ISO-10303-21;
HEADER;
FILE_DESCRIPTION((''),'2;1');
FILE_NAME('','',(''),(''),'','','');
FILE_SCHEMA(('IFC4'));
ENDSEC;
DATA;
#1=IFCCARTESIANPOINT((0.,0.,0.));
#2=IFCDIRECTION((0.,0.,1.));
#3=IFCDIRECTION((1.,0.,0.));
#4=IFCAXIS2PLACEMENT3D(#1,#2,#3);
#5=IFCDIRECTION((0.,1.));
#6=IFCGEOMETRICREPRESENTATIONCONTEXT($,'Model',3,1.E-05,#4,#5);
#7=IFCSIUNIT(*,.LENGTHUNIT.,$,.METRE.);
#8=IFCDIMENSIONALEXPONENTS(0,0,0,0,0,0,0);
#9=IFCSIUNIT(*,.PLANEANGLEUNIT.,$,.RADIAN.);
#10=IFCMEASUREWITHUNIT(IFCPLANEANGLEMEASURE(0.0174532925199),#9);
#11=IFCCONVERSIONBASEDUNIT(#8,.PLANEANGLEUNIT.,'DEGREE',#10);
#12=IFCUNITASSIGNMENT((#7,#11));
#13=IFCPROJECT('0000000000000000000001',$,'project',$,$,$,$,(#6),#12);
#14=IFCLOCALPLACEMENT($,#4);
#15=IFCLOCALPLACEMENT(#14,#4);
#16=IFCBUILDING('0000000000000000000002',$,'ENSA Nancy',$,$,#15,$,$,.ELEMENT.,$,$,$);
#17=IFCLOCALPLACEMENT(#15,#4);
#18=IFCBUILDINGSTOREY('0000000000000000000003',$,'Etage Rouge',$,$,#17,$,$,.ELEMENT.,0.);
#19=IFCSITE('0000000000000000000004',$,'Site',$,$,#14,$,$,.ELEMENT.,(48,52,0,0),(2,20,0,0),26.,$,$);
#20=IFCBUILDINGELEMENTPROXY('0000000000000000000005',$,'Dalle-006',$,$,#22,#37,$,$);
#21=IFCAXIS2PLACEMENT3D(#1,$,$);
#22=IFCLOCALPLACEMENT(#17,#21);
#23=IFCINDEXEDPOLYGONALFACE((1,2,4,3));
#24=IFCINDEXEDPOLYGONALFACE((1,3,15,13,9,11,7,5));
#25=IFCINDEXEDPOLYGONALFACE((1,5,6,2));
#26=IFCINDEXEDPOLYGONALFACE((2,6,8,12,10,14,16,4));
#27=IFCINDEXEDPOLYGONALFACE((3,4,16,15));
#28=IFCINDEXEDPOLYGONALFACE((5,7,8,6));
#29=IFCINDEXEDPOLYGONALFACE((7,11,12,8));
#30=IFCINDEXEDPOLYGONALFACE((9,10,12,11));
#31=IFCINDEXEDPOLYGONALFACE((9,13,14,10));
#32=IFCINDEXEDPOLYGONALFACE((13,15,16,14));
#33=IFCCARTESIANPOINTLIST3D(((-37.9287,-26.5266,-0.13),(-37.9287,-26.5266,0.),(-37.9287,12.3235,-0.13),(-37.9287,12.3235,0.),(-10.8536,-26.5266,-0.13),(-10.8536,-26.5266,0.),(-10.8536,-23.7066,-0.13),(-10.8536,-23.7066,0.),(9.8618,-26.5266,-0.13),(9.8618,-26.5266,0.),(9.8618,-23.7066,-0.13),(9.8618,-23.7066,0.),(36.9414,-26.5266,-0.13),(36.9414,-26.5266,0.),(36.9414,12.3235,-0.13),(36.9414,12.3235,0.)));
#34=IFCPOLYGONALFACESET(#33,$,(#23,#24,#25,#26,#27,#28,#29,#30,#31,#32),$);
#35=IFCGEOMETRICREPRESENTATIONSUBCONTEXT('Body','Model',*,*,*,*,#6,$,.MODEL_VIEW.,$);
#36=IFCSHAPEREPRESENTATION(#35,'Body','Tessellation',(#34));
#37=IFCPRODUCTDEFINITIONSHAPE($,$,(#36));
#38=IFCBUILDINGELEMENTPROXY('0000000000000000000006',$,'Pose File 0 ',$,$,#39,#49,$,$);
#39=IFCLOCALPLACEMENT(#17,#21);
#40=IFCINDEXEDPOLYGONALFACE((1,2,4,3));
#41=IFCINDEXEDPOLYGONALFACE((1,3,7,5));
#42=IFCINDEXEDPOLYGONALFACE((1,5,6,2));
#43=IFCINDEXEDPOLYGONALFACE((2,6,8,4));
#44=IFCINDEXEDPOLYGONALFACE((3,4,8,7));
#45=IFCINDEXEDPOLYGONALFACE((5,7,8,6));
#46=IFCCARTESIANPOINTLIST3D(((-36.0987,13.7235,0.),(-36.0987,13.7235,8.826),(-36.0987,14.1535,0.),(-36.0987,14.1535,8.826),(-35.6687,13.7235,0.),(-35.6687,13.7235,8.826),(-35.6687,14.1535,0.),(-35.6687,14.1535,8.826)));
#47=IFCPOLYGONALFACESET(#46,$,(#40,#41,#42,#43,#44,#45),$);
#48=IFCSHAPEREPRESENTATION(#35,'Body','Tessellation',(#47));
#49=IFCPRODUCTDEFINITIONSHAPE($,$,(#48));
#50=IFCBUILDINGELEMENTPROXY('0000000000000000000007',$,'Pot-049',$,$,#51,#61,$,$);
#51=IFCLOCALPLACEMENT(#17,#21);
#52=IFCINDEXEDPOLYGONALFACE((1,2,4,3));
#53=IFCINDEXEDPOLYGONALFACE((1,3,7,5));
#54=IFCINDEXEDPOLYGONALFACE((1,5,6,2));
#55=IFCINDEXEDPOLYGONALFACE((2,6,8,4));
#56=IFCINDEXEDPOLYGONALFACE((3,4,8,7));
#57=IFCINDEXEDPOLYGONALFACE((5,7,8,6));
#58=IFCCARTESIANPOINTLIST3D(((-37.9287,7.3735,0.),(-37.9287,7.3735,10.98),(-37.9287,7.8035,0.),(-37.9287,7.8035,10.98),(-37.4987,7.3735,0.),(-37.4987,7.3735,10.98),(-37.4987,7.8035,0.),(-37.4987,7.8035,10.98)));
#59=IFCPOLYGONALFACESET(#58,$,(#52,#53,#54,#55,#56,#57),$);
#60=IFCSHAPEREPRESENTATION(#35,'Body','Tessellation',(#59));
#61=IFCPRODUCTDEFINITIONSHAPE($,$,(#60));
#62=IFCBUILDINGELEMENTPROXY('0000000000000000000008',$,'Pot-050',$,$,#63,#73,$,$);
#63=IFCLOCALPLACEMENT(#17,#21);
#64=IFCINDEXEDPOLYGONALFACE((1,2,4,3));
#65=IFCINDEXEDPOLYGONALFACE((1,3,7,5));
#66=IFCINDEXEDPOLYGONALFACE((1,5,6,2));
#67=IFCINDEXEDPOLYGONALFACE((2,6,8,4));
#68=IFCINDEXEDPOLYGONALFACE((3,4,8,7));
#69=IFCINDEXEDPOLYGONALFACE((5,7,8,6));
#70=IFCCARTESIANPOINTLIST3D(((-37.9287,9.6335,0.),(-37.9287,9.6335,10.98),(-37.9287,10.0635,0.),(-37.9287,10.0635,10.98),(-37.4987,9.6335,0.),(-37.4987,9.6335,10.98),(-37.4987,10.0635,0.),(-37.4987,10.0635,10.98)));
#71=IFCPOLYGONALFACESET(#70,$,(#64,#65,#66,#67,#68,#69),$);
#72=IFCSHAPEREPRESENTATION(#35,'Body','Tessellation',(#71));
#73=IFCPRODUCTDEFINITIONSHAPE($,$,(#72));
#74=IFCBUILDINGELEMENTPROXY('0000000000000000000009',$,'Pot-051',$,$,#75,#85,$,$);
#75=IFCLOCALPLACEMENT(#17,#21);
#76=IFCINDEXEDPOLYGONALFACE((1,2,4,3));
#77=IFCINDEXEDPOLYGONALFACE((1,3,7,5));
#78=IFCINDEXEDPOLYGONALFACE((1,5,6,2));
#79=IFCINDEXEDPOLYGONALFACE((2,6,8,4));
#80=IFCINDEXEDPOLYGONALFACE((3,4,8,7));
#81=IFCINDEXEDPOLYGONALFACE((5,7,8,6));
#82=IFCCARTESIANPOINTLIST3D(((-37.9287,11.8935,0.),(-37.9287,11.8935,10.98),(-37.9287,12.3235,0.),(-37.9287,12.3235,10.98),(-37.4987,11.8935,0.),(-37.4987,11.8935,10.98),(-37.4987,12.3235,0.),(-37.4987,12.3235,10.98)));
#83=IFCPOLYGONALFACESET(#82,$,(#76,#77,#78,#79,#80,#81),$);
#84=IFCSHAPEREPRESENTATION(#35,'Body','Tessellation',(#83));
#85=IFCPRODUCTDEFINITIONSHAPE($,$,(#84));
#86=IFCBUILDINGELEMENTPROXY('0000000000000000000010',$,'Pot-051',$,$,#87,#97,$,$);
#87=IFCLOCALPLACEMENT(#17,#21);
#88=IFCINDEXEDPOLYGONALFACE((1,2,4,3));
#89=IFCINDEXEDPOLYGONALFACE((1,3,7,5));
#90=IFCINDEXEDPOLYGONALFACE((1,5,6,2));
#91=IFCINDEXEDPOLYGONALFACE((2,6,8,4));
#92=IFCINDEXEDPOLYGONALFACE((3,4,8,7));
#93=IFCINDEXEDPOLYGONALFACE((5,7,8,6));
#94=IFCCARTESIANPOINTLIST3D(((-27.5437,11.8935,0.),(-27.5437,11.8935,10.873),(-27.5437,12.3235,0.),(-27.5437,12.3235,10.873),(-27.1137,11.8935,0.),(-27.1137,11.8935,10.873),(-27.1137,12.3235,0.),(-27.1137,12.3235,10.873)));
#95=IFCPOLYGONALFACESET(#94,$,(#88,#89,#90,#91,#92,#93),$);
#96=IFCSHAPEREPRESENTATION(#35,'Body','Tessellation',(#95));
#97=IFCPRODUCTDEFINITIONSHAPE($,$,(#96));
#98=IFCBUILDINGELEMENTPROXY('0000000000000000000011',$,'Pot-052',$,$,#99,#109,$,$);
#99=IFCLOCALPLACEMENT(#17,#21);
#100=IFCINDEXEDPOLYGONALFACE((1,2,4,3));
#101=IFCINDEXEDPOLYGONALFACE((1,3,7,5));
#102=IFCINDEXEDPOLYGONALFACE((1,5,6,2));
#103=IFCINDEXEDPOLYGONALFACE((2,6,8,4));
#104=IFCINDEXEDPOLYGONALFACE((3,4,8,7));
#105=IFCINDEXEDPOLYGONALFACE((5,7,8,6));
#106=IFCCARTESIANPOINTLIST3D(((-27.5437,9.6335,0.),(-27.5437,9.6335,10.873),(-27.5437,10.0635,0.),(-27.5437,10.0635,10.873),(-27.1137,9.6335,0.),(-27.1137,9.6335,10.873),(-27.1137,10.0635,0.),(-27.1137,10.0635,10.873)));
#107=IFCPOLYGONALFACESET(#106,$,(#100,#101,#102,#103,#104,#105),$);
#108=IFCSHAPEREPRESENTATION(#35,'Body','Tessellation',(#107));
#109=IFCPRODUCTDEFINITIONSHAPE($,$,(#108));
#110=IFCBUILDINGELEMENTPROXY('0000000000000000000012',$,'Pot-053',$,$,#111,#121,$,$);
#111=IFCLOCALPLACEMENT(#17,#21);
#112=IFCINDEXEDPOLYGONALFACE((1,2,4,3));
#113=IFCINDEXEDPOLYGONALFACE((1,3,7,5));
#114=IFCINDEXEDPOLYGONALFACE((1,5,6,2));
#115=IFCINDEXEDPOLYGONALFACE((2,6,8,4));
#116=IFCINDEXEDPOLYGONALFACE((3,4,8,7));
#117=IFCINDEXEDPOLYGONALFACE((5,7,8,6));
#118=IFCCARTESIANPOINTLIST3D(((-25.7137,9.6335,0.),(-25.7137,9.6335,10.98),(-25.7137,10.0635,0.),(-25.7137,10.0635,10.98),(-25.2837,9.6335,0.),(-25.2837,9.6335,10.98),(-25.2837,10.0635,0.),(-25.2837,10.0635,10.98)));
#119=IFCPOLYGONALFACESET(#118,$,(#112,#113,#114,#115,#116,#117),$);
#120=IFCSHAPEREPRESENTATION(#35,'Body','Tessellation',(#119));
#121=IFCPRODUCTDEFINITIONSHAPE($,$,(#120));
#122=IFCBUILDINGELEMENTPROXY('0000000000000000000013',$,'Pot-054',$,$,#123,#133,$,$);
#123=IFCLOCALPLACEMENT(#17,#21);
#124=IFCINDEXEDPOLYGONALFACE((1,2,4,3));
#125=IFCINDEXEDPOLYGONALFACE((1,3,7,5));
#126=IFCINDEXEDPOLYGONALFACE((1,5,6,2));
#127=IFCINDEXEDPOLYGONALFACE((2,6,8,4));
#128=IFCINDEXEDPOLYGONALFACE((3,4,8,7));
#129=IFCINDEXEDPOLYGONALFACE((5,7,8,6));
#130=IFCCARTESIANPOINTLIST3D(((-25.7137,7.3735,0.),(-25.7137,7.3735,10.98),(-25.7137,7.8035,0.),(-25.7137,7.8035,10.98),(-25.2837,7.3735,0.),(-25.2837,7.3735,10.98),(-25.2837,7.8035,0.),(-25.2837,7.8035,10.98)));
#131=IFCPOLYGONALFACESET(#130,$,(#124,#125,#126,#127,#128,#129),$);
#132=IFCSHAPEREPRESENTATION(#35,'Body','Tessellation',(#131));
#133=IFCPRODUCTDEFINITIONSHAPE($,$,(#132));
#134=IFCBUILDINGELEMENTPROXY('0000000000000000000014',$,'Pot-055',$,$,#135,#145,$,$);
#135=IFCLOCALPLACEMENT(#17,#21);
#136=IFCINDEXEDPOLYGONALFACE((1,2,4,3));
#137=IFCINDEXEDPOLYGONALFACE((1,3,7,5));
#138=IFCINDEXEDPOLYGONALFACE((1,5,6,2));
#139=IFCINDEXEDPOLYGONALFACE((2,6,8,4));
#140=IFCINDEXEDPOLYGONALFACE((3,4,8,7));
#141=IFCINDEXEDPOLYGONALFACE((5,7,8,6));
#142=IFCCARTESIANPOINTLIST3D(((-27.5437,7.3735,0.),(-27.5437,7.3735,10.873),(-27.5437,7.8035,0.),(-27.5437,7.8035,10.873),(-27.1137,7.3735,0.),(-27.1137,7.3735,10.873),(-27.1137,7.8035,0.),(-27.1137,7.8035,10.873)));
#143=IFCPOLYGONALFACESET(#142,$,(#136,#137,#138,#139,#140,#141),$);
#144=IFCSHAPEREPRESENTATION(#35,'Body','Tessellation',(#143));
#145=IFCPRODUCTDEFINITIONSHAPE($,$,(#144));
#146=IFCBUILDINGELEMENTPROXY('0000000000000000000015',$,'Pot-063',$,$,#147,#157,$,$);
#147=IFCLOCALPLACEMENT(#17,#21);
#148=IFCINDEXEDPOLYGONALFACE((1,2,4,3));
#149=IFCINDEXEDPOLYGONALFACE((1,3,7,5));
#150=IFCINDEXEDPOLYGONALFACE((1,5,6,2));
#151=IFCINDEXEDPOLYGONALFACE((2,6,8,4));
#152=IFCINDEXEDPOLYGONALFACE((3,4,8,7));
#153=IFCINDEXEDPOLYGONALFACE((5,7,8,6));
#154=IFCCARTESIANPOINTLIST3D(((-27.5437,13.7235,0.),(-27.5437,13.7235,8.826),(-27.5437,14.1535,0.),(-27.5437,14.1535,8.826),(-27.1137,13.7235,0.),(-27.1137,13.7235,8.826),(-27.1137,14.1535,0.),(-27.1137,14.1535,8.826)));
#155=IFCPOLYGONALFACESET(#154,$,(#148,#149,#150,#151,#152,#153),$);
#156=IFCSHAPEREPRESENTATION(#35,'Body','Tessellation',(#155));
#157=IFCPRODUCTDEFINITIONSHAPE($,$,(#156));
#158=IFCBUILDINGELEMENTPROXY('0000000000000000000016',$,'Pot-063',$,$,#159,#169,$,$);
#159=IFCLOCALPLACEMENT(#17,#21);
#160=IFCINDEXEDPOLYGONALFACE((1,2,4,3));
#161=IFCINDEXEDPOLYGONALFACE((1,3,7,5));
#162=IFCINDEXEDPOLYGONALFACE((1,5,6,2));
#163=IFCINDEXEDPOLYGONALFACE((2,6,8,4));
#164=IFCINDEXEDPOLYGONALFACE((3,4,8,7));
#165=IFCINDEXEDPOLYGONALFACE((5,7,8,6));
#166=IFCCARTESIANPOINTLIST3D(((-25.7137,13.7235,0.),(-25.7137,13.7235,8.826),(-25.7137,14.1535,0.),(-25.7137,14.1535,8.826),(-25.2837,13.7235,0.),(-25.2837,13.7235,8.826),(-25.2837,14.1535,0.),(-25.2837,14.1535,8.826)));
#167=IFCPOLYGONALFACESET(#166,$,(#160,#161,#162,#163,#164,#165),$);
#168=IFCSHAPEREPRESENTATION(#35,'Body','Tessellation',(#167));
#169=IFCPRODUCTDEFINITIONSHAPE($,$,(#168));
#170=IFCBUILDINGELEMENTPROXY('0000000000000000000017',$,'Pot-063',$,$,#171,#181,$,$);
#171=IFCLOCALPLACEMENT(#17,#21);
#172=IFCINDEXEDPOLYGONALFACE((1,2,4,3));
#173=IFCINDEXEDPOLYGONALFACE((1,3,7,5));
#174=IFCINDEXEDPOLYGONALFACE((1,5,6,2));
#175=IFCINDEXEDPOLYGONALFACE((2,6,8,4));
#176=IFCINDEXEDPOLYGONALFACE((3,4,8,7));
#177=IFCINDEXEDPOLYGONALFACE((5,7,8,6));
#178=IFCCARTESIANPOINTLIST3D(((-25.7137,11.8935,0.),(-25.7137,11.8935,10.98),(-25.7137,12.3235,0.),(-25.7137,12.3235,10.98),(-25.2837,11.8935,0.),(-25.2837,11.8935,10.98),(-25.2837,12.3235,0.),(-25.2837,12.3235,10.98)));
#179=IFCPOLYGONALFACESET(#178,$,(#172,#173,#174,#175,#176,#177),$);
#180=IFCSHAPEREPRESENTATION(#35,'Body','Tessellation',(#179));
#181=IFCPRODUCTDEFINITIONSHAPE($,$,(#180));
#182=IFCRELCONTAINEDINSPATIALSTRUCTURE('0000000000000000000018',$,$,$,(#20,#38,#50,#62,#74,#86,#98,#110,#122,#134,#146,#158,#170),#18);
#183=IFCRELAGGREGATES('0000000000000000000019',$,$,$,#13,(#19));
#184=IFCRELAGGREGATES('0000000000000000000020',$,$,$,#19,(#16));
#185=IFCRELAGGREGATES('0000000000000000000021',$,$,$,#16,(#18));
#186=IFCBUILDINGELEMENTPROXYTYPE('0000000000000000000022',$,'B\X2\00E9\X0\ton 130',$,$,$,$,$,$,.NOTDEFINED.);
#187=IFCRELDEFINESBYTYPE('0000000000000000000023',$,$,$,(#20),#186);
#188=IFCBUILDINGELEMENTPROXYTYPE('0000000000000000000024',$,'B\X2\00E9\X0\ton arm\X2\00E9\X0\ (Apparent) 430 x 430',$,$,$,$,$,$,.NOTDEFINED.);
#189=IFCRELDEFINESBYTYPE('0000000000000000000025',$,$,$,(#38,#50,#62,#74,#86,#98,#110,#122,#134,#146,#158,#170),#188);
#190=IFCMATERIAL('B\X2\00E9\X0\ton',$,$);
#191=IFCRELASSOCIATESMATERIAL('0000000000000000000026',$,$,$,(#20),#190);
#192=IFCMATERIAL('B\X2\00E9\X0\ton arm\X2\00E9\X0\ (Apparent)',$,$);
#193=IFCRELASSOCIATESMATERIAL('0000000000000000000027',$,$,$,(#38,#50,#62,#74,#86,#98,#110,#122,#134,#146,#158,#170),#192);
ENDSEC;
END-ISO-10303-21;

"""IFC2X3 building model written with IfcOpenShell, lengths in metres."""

from ifc_helpers import new_model, entity, si_unit, converted_unit, direction, frame, origin_with_axes, origin_2d_with_axis, place, context, subcontext, project, spatial, polyline, rectangle, outline, extrude, material, type_object, element, save


model = new_model("IFC2X3")

# Units and contexts
model_context = context("Model", 3, precision=1e-05, world=origin_with_axes(), true_north=direction((0.0, 1.0)))
body_context = subcontext(model_context, "Body", "Model", "MODEL_VIEW")
ifc_project = project(units=[si_unit("LENGTHUNIT", "METRE"), converted_unit("PLANEANGLEUNIT", "DEGREE", entity("IfcPlaneAngleMeasure", 0.0174532925199), si_unit("PLANEANGLEUNIT", "RADIAN"), dimensions=[0, 0, 0, 0, 0, 0, 0])], contexts=[model_context])

# Site, building, storey
site_placement = place(None, origin_with_axes())
site = spatial("IfcSite", under=ifc_project, at=site_placement, Name="Site", CompositionType="ELEMENT", RefLatitude=(48, 52, 0, 0), RefLongitude=(2, 20, 0, 0), RefElevation=26.0)
building_placement = place(site_placement, origin_with_axes())
building = spatial("IfcBuilding", under=site, at=building_placement, Name="ENSA Nancy", CompositionType="ELEMENT")
storey_placement = place(building_placement, origin_with_axes())
storey = spatial("IfcBuildingStorey", under=building, at=storey_placement, Name="Etage Rouge", CompositionType="ELEMENT", Elevation=0.0)

# Building element proxies
ifc_material_1 = material(Name="Béton")
building_element_proxy_type_1 = type_object("IfcBuildingElementProxyType", Name="Béton 130", PredefinedType="NOTDEFINED")
proxy_1_placement = place(storey_placement, frame((-37.9287, 12.3235, 0.0), z_axis=(0.0, 0.0, 1.0), x_axis=(1.0, 0.0, 0.0)))
element("IfcBuildingElementProxy", 1, at=proxy_1_placement, inside=storey, type_object=building_element_proxy_type_1, material=ifc_material_1, Name="Dalle-006", context=body_context, shape_type="SweptSolid", body=[
    extrude(outline(polyline([(0.0, 0.0), (0.0, -38.85), (27.0751, -38.85), (27.0751, -36.03), (47.7905, -36.03), (47.7905, -38.85), (74.8701, -38.85), (74.8701, 0.0), (0.0, 0.0)])), frame((0.0, 0.0, -0.13), z_axis=(0.0, 0.0, 1.0), x_axis=(1.0, 0.0, 0.0)), (0.0, 0.0, 1.0), 0.13),
])
ifc_material_2 = material(Name="Béton armé (Apparent)")
building_element_proxy_type_2 = type_object("IfcBuildingElementProxyType", Name="Béton armé (Apparent) 430 x 430", PredefinedType="NOTDEFINED")
proxy_2_placement = place(storey_placement, frame((-35.8837, 13.9385, 0.0), z_axis=(0.0, 0.0, 1.0), x_axis=(1.0, 0.0, 0.0)))
element("IfcBuildingElementProxy", 2, at=proxy_2_placement, inside=storey, type_object=building_element_proxy_type_2, material=ifc_material_2, Name="Pose File 0 ", context=body_context, shape_type="SweptSolid", body=[
    extrude(rectangle(XDim=0.43, YDim=0.43, at=origin_2d_with_axis()), frame((0.0, 0.0, 0.0), z_axis=(0.0, 0.0, -1.0), x_axis=(-1.0, 0.0, 0.0)), (0.0, 0.0, -1.0), 8.826),
])
for number, where, z_axis, x_axis, name in (
    (3, (-37.7137, 7.5885, 0.0), (0.0, 0.0, 1.0), (1.0, 0.0, 0.0), "Pot-049"),
    (4, (-37.7137, 9.8485, 0.0), (0.0, 0.0, 1.0), (1.0, 0.0, 0.0), "Pot-050"),
    (5, (-37.7137, 12.1085, 0.0), (0.0, 0.0, 1.0), (1.0, 0.0, 0.0), "Pot-051"),
):
    element("IfcBuildingElementProxy", number, at=place(storey_placement, frame(where, z_axis=z_axis, x_axis=x_axis)), inside=storey, type_object=building_element_proxy_type_2, material=ifc_material_2, Name=name, context=body_context, shape_type="SweptSolid", body=[
        extrude(rectangle(XDim=0.43, YDim=0.43, at=origin_2d_with_axis()), origin_with_axes(), (0.0, 0.0, 1.0), 10.98),
    ])
for number, where, z_axis, x_axis, name in (
    (6, (-27.3287, 12.1085, 0.0), (0.0, 0.0, 1.0), (1.0, 0.0, 0.0), "Pot-051"),
    (7, (-27.3287, 9.8485, 0.0), (0.0, 0.0, 1.0), (1.0, 0.0, 0.0), "Pot-052"),
):
    element("IfcBuildingElementProxy", number, at=place(storey_placement, frame(where, z_axis=z_axis, x_axis=x_axis)), inside=storey, type_object=building_element_proxy_type_2, material=ifc_material_2, Name=name, context=body_context, shape_type="SweptSolid", body=[
        extrude(rectangle(XDim=0.43, YDim=0.43, at=origin_2d_with_axis()), origin_with_axes(), (0.0, 0.0, 1.0), 10.873),
    ])
for number, where, z_axis, x_axis, name in (
    (8, (-25.4987, 9.8485, 0.0), (0.0, 0.0, 1.0), (1.0, 0.0, 0.0), "Pot-053"),
    (9, (-25.4987, 7.5885, 0.0), (0.0, 0.0, 1.0), (1.0, 0.0, 0.0), "Pot-054"),
):
    element("IfcBuildingElementProxy", number, at=place(storey_placement, frame(where, z_axis=z_axis, x_axis=x_axis)), inside=storey, type_object=building_element_proxy_type_2, material=ifc_material_2, Name=name, context=body_context, shape_type="SweptSolid", body=[
        extrude(rectangle(XDim=0.43, YDim=0.43, at=origin_2d_with_axis()), origin_with_axes(), (0.0, 0.0, 1.0), 10.98),
    ])
proxy_3_placement = place(storey_placement, frame((-27.3287, 7.5885, 0.0), z_axis=(0.0, 0.0, 1.0), x_axis=(1.0, 0.0, 0.0)))
element("IfcBuildingElementProxy", 10, at=proxy_3_placement, inside=storey, type_object=building_element_proxy_type_2, material=ifc_material_2, Name="Pot-055", context=body_context, shape_type="SweptSolid", body=[
    extrude(rectangle(XDim=0.43, YDim=0.43, at=origin_2d_with_axis()), origin_with_axes(), (0.0, 0.0, 1.0), 10.873),
])
for number, where, z_axis, x_axis, name in (
    (11, (-27.3287, 13.9385, 0.0), (0.0, 0.0, 1.0), (1.0, 0.0, 0.0), "Pot-063"),
    (12, (-25.4987, 13.9385, 0.0), (0.0, 0.0, 1.0), (1.0, 0.0, 0.0), "Pot-063"),
):
    element("IfcBuildingElementProxy", number, at=place(storey_placement, frame(where, z_axis=z_axis, x_axis=x_axis)), inside=storey, type_object=building_element_proxy_type_2, material=ifc_material_2, Name=name, context=body_context, shape_type="SweptSolid", body=[
        extrude(rectangle(XDim=0.43, YDim=0.43, at=origin_2d_with_axis()), origin_with_axes(), (0.0, 0.0, 1.0), 8.826),
    ])
proxy_4_placement = place(storey_placement, frame((-25.4987, 12.1085, 0.0), z_axis=(0.0, 0.0, 1.0), x_axis=(1.0, 0.0, 0.0)))
element("IfcBuildingElementProxy", 13, at=proxy_4_placement, inside=storey, type_object=building_element_proxy_type_2, material=ifc_material_2, Name="Pot-063", context=body_context, shape_type="SweptSolid", body=[
    extrude(rectangle(XDim=0.43, YDim=0.43, at=origin_2d_with_axis()), origin_with_axes(), (0.0, 0.0, 1.0), 10.98),
])

save(model, "model.ifc")
